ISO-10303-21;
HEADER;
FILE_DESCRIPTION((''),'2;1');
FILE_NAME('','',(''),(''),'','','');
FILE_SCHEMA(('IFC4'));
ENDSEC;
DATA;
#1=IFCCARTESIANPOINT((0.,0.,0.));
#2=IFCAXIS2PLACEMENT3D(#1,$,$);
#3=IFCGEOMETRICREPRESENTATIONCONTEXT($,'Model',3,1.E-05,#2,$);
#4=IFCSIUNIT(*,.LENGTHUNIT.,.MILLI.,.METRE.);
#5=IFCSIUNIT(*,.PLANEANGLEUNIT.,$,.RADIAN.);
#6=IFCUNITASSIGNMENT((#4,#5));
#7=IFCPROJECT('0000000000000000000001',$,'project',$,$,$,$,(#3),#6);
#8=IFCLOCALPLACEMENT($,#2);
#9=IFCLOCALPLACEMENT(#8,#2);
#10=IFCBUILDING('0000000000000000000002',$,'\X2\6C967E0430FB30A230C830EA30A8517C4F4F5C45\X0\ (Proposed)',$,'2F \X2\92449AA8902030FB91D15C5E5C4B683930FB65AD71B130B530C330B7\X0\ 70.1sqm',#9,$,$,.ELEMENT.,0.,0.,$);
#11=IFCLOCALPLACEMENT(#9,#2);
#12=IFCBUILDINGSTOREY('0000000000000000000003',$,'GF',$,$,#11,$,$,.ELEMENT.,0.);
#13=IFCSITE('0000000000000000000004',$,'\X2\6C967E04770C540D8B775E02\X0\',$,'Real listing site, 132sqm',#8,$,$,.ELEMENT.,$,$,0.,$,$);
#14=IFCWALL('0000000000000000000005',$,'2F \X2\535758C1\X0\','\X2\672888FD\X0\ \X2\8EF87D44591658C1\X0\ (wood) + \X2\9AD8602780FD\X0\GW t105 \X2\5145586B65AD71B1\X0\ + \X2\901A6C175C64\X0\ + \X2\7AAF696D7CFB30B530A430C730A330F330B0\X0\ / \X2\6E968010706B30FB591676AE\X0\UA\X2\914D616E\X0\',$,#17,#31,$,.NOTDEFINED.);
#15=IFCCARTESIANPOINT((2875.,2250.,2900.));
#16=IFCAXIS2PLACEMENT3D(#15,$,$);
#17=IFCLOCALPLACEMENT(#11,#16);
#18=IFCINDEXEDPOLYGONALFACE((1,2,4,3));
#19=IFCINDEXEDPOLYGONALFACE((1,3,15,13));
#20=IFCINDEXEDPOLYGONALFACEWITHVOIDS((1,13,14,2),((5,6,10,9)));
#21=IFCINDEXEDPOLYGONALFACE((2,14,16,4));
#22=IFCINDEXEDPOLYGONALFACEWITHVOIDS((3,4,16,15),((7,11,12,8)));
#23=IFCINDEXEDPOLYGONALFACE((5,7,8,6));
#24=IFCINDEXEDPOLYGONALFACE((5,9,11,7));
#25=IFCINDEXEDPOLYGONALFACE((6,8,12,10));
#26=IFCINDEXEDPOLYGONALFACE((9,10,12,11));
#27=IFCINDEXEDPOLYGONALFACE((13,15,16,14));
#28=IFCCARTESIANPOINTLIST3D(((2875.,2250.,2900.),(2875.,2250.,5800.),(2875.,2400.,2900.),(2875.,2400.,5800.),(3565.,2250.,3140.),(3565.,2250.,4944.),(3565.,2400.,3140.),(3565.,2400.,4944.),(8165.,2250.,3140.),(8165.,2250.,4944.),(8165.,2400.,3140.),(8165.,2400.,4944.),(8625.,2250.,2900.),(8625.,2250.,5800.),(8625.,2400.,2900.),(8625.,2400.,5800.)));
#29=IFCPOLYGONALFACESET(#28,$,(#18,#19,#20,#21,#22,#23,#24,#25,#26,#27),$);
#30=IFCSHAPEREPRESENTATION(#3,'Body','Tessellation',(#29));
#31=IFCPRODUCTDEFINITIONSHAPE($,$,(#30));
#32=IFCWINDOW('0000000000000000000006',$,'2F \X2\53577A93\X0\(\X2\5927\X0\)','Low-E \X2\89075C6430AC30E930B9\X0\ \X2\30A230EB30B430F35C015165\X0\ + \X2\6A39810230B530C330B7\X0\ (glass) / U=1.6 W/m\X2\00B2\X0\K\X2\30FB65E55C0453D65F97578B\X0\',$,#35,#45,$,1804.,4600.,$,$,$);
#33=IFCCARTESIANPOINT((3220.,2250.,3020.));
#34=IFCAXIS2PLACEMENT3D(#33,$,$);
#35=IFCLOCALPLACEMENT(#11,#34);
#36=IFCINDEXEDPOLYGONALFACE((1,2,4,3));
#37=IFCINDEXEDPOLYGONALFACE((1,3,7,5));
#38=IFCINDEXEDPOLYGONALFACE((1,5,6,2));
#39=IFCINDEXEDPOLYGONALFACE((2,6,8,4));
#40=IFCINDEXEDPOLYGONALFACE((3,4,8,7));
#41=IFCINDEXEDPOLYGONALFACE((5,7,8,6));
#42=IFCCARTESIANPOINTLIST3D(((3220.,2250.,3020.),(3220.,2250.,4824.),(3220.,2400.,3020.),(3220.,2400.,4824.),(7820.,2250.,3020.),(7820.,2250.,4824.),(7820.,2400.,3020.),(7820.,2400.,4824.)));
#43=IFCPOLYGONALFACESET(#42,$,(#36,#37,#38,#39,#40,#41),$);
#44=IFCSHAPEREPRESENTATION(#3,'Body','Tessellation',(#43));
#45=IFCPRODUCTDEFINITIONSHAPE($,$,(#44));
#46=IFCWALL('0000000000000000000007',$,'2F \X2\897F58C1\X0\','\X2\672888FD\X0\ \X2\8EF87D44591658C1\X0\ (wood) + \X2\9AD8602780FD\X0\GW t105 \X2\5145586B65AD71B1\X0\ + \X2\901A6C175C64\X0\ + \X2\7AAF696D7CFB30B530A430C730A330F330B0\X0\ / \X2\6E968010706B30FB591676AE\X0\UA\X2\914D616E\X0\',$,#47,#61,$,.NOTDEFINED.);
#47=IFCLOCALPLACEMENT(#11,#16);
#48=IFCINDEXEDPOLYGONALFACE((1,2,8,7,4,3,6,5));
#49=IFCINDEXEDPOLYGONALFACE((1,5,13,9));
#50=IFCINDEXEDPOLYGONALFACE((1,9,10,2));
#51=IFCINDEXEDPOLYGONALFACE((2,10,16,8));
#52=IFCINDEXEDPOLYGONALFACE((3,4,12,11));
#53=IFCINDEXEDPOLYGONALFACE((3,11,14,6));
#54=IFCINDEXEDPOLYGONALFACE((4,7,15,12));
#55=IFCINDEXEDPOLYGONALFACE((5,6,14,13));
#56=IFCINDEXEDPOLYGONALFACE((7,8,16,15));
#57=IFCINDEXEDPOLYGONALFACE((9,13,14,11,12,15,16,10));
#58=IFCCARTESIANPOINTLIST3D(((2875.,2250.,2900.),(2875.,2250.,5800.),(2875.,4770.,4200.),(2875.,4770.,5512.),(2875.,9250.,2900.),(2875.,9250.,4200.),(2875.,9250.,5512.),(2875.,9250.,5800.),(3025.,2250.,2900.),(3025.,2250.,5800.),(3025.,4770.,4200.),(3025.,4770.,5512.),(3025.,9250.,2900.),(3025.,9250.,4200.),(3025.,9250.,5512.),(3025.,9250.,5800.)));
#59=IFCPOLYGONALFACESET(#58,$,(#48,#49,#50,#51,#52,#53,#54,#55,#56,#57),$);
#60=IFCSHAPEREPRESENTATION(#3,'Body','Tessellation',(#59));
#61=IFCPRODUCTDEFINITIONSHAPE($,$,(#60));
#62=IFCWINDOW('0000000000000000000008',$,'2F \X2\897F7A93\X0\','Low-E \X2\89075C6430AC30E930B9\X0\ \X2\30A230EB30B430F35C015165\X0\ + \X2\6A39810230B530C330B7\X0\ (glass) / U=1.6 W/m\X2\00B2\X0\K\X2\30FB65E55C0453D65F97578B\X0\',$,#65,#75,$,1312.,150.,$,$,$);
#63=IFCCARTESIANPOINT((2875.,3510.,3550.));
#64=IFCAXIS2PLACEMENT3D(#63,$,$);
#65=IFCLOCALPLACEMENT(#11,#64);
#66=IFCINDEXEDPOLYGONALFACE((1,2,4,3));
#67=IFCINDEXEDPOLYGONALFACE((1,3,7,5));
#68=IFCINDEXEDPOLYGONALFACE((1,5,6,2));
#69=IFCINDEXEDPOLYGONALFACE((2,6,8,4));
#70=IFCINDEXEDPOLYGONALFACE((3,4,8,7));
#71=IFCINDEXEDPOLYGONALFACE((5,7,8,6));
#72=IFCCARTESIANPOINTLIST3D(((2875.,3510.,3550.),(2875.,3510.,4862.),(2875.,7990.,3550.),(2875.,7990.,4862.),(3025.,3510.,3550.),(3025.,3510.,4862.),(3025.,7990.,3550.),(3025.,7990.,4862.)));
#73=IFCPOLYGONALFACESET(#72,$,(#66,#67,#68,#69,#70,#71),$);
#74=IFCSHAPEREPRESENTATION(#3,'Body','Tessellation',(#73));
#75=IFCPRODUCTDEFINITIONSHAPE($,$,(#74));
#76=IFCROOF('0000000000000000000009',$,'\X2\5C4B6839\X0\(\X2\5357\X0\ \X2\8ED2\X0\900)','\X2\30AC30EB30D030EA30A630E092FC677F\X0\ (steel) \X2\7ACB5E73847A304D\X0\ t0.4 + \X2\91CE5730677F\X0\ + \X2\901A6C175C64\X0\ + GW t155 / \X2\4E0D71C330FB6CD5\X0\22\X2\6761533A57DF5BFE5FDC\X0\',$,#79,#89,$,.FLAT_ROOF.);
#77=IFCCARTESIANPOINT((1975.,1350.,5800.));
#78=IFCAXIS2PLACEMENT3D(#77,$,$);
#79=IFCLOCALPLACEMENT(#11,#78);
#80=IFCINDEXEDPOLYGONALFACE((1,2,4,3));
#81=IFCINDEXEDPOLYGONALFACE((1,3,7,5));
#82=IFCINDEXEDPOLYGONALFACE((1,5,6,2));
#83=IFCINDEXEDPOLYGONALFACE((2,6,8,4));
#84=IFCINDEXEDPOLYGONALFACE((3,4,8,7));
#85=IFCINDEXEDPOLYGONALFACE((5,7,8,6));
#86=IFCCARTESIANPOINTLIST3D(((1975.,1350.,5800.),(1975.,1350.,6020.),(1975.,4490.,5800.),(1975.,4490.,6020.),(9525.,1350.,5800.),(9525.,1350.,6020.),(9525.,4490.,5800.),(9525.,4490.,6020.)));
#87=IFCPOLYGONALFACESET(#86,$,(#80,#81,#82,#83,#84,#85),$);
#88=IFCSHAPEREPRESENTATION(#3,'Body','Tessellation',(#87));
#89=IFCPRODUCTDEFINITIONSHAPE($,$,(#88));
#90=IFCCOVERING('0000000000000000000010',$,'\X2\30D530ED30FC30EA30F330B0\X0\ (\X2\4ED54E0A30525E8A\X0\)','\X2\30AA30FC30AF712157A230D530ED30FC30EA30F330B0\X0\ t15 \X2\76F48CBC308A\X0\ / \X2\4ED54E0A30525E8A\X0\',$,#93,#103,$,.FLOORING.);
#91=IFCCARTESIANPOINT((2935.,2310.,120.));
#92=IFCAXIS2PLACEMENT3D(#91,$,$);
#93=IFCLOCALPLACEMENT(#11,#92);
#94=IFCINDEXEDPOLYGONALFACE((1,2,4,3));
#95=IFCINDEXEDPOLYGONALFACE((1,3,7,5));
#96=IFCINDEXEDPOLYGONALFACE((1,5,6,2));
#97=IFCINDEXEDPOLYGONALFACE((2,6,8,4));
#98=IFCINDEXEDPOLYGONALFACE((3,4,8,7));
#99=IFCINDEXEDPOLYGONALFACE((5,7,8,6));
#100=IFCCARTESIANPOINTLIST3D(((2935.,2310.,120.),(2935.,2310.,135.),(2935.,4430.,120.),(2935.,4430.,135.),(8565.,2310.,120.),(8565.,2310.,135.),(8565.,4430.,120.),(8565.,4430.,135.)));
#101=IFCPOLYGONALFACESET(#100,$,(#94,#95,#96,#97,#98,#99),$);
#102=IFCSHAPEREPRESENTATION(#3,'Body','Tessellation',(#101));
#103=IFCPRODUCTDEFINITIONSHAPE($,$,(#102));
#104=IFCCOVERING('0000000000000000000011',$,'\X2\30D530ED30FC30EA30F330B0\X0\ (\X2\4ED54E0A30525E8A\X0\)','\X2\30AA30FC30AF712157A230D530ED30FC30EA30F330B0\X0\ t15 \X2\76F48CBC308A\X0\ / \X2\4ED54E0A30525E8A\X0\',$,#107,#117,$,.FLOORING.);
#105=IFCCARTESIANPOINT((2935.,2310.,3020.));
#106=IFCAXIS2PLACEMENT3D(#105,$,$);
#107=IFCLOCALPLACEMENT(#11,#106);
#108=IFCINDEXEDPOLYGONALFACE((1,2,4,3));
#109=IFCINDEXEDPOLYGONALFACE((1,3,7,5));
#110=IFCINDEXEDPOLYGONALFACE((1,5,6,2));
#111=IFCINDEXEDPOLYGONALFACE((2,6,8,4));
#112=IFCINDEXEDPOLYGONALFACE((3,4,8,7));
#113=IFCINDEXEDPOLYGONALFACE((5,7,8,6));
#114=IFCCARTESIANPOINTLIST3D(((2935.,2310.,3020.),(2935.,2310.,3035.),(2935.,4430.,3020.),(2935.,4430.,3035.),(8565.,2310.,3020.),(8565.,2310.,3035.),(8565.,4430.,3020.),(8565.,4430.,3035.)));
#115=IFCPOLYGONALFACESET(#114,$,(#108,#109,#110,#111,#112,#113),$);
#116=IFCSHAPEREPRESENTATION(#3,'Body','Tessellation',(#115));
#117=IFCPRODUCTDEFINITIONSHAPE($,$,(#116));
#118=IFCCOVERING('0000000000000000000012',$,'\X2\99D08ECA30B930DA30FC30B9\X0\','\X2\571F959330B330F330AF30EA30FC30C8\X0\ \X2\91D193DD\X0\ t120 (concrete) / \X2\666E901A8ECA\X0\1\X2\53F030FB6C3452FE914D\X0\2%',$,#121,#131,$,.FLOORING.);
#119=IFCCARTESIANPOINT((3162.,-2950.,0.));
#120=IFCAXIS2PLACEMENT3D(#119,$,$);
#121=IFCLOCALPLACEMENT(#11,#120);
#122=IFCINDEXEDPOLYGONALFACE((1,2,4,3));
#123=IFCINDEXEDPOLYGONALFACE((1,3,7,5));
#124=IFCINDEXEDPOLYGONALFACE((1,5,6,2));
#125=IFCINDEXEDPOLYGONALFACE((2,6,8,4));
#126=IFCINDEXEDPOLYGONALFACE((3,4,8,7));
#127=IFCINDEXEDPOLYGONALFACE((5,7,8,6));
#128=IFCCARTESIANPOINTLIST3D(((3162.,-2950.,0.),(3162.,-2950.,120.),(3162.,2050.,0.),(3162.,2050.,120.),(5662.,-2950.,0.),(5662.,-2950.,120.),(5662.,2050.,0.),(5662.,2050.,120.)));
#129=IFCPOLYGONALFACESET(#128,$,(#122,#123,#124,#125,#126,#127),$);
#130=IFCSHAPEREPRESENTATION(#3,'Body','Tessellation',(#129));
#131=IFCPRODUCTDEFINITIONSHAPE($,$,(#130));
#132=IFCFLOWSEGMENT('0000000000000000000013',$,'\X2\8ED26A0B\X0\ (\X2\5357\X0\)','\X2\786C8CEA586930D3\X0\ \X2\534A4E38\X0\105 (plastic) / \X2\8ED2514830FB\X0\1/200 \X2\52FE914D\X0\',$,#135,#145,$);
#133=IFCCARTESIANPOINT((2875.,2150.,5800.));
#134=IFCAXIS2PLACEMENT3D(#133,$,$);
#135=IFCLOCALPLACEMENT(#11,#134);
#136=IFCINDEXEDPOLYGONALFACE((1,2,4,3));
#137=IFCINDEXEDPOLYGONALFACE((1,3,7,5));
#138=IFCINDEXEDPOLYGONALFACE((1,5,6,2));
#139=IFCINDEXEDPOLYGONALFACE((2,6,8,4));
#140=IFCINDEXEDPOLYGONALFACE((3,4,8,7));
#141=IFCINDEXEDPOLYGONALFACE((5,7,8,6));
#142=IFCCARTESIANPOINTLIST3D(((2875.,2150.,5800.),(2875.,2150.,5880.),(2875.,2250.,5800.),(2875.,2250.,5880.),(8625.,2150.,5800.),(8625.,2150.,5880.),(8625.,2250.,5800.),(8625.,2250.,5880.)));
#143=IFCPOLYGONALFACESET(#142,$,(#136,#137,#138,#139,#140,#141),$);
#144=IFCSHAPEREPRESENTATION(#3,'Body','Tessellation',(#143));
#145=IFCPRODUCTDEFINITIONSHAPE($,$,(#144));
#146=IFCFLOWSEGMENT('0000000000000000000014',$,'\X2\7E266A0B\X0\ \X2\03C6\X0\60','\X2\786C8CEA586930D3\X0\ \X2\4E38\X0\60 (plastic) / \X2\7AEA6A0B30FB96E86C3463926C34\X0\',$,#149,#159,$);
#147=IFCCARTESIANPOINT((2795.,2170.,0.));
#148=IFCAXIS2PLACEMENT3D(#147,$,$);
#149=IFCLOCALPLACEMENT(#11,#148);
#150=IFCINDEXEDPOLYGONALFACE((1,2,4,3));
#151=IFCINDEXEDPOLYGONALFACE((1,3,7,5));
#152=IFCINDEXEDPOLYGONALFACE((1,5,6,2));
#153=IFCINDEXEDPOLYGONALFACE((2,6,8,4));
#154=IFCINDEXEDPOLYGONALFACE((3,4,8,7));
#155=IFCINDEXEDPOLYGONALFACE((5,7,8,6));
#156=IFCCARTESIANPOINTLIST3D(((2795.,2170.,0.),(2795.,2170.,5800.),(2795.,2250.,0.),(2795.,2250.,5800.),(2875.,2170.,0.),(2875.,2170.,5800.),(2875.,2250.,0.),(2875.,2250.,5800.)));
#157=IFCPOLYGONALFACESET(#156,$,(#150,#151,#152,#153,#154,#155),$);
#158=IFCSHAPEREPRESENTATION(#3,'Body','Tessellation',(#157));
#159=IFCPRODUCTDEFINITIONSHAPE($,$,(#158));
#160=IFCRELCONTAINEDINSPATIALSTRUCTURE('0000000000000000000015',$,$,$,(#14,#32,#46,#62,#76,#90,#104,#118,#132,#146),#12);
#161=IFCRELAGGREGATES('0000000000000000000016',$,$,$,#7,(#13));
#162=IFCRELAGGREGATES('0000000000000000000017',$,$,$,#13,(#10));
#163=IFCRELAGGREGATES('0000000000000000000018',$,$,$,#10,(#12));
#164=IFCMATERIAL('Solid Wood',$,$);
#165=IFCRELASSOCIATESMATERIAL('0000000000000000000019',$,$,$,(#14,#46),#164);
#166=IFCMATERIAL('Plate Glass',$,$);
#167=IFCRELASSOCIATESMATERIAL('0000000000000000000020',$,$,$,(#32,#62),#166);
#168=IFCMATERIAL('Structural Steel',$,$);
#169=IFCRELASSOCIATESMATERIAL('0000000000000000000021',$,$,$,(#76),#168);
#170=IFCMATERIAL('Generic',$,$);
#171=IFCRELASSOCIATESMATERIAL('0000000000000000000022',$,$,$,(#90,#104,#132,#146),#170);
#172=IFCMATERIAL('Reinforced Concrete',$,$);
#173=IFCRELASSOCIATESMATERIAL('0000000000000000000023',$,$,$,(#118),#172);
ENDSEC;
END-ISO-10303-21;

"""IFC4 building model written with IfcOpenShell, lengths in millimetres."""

from ifc_helpers import new_model, si_unit, frame, frame_2d, origin, place, context, project, spatial, rectangle, extrude, material, element, fill, save


model = new_model("IFC4")

# Units and contexts
model_context = context("Model", 3, precision=1e-05, world=origin())
ifc_project = project(units=[si_unit("LENGTHUNIT", "METRE", prefix="MILLI"), si_unit("PLANEANGLEUNIT", "RADIAN")], contexts=[model_context])

# Site, building, storey
site_placement = place(None, origin())
site = spatial("IfcSite", under=ifc_project, at=site_placement, Name="沖縄県名護市", ObjectType="Real listing site, 132sqm", CompositionType="ELEMENT", RefElevation=0.0)
building_placement = place(site_placement, origin())
building = spatial("IfcBuilding", under=site, at=building_placement, Name="沖縄・アトリエ兼住居 (Proposed)", ObjectType="2F 鉄骨造・金属屋根・断熱サッシ 70.1sqm", CompositionType="ELEMENT", ElevationOfRefHeight=0.0, ElevationOfTerrain=0.0)
storey_placement = place(building_placement, origin())
storey = spatial("IfcBuildingStorey", under=building, at=storey_placement, Name="GF", CompositionType="ELEMENT", Elevation=0.0)

# Shared definitions
ifc_material_1 = material(Name="Solid Wood")

# Shared definitions
ifc_material_2 = material(Name="Reinforced Concrete")

# Shared definitions
ifc_material_3 = material(Name="Plate Glass")

# Walls, openings, windows
wall_1_placement = place(storey_placement, frame((2875.0, 2250.0, 2900.0)))
wall_1 = element("IfcWall", 1, at=wall_1_placement, inside=storey, material=ifc_material_1, Name="2F 南壁", Description="木製 軸組外壁 (wood) + 高性能GW t105 充填断熱 + 通気層 + 窯業系サイディング / 準耐火・外皮UA配慮", PredefinedType="NOTDEFINED", context=model_context, shape_type="SweptSolid", body=[
    extrude(rectangle(XDim=5750.0, YDim=150.0, at=frame_2d((2875.0, 75.0))), frame((2875.0, 2250.0, 2900.0)), (0.0, 0.0, 1.0), 2900.0),
])
opening_1_placement = place(storey_placement, frame((3220.0, 2250.0, 3020.0)))
opening_1 = element("IfcOpeningElement", 2, at=opening_1_placement, cuts=wall_1, PredefinedType="NOTDEFINED", context=model_context, shape_type="SweptSolid", body=[
    extrude(rectangle(XDim=4600.0, YDim=150.0, at=frame_2d((2300.0, 75.0))), frame((3220.0, 2250.0, 3020.0)), (0.0, 0.0, 1.0), 1804.0),
])
window_1_placement = place(storey_placement, frame((3220.0, 2250.0, 3020.0)))
window_1 = element("IfcWindow", 3, at=window_1_placement, inside=storey, material=ifc_material_3, Name="2F 南窓(大)", Description="Low-E 複層ガラス アルゴン封入 + 樹脂サッシ (glass) / U=1.6 W/m²K・日射取得型", OverallHeight=1804.0, OverallWidth=4600.0, context=model_context, shape_type="SweptSolid", body=[
    extrude(rectangle(XDim=4600.0, YDim=150.0, at=frame_2d((2300.0, 75.0))), frame((3220.0, 2250.0, 3020.0)), (0.0, 0.0, 1.0), 1804.0),
])
fill(opening_1, window_1)
wall_2_placement = place(storey_placement, frame((2875.0, 2250.0, 2900.0)))
wall_2 = element("IfcWall", 4, at=wall_2_placement, inside=storey, material=ifc_material_1, Name="2F 西壁", Description="木製 軸組外壁 (wood) + 高性能GW t105 充填断熱 + 通気層 + 窯業系サイディング / 準耐火・外皮UA配慮", PredefinedType="NOTDEFINED", context=model_context, shape_type="SweptSolid", body=[
    extrude(rectangle(XDim=150.0, YDim=7000.0, at=frame_2d((75.0, 3500.0))), frame((2875.0, 2250.0, 2900.0)), (0.0, 0.0, 1.0), 2900.0),
])
opening_2_placement = place(storey_placement, frame((2875.0, 3510.0, 3550.0)))
opening_2 = element("IfcOpeningElement", 5, at=opening_2_placement, cuts=wall_2, PredefinedType="NOTDEFINED", context=model_context, shape_type="SweptSolid", body=[
    extrude(rectangle(XDim=150.0, YDim=4480.0, at=frame_2d((75.0, 2240.0))), frame((2875.0, 3510.0, 3550.0)), (0.0, 0.0, 1.0), 1312.0),
])
window_2_placement = place(storey_placement, frame((2875.0, 3510.0, 3550.0)))
window_2 = element("IfcWindow", 6, at=window_2_placement, inside=storey, material=ifc_material_3, Name="2F 西窓", Description="Low-E 複層ガラス アルゴン封入 + 樹脂サッシ (glass) / U=1.6 W/m²K・日射取得型", OverallHeight=1312.0, OverallWidth=150.0, context=model_context, shape_type="SweptSolid", body=[
    extrude(rectangle(XDim=150.0, YDim=4480.0, at=frame_2d((75.0, 2240.0))), frame((2875.0, 3510.0, 3550.0)), (0.0, 0.0, 1.0), 1312.0),
])
fill(opening_2, window_2)

# Roof
ifc_material_4 = material(Name="Structural Steel")
for number, where, name in (
    (7, (1975.0, 1350.0, 5800.0), "屋根(南 軒900)"),
):
    element("IfcRoof", number, at=place(storey_placement, frame(where)), inside=storey, material=ifc_material_4, Name=name, Description="ガルバリウム鋼板 (steel) 立平葺き t0.4 + 野地板 + 通気層 + GW t155 / 不燃・法22条区域対応", PredefinedType="FLAT_ROOF", context=model_context, shape_type="SweptSolid", body=[
        extrude(rectangle(XDim=7550.0, YDim=3140.0, at=frame_2d((3775.0, 1570.0))), frame((1975.0, 1350.0, 5800.0)), (0.0, 0.0, 1.0), 220.0),
    ])

# Coverings
ifc_material_5 = material(Name="Generic")
covering_1_placement = place(storey_placement, frame((2935.0, 2310.0, 120.0)))
element("IfcCovering", 8, at=covering_1_placement, inside=storey, material=ifc_material_5, Name="フローリング (仕上げ床)", Description="オーク無垢フローリング t15 直貼り / 仕上げ床", PredefinedType="FLOORING", context=model_context, shape_type="SweptSolid", body=[
    extrude(rectangle(XDim=5630.0, YDim=2120.0, at=frame_2d((2815.0, 1060.0))), frame((2935.0, 2310.0, 120.0)), (0.0, 0.0, 1.0), 15.0),
])
covering_2_placement = place(storey_placement, frame((2935.0, 2310.0, 3020.0)))
element("IfcCovering", 9, at=covering_2_placement, inside=storey, material=ifc_material_5, Name="フローリング (仕上げ床)", Description="オーク無垢フローリング t15 直貼り / 仕上げ床", PredefinedType="FLOORING", context=model_context, shape_type="SweptSolid", body=[
    extrude(rectangle(XDim=5630.0, YDim=2120.0, at=frame_2d((2815.0, 1060.0))), frame((2935.0, 2310.0, 3020.0)), (0.0, 0.0, 1.0), 15.0),
])
covering_3_placement = place(storey_placement, frame((3162.0, -2950.0, 0.0)))
element("IfcCovering", 10, at=covering_3_placement, inside=storey, material=ifc_material_2, Name="駐車スペース", Description="土間コンクリート 金鏝 t120 (concrete) / 普通車1台・水勾配2%", PredefinedType="FLOORING", context=model_context, shape_type="SweptSolid", body=[
    extrude(rectangle(XDim=2500.0, YDim=5000.0, at=frame_2d((1250.0, 2500.0))), frame((3162.0, -2950.0, 0.0)), (0.0, 0.0, 1.0), 120.0),
])

# Flow segments
flow_segment_1_placement = place(storey_placement, frame((2875.0, 2150.0, 5800.0)))
element("IfcFlowSegment", 11, at=flow_segment_1_placement, inside=storey, material=ifc_material_5, Name="軒樋 (南)", Description="硬質塩ビ 半丸105 (plastic) / 軒先・1/200 勾配", context=model_context, shape_type="SweptSolid", body=[
    extrude(rectangle(XDim=5750.0, YDim=100.0, at=frame_2d((2875.0, 50.0))), frame((2875.0, 2150.0, 5800.0)), (0.0, 0.0, 1.0), 80.0),
])
flow_segment_2_placement = place(storey_placement, frame((2795.0, 2170.0, 0.0)))
element("IfcFlowSegment", 12, at=flow_segment_2_placement, inside=storey, material=ifc_material_5, Name="縦樋 φ60", Description="硬質塩ビ 丸60 (plastic) / 竪樋・雨水排水", context=model_context, shape_type="SweptSolid", body=[
    extrude(rectangle(XDim=80.0, YDim=80.0, at=frame_2d((40.0, 40.0))), frame((2795.0, 2170.0, 0.0)), (0.0, 0.0, 1.0), 5800.0),
])

save(model, "model.ifc")
